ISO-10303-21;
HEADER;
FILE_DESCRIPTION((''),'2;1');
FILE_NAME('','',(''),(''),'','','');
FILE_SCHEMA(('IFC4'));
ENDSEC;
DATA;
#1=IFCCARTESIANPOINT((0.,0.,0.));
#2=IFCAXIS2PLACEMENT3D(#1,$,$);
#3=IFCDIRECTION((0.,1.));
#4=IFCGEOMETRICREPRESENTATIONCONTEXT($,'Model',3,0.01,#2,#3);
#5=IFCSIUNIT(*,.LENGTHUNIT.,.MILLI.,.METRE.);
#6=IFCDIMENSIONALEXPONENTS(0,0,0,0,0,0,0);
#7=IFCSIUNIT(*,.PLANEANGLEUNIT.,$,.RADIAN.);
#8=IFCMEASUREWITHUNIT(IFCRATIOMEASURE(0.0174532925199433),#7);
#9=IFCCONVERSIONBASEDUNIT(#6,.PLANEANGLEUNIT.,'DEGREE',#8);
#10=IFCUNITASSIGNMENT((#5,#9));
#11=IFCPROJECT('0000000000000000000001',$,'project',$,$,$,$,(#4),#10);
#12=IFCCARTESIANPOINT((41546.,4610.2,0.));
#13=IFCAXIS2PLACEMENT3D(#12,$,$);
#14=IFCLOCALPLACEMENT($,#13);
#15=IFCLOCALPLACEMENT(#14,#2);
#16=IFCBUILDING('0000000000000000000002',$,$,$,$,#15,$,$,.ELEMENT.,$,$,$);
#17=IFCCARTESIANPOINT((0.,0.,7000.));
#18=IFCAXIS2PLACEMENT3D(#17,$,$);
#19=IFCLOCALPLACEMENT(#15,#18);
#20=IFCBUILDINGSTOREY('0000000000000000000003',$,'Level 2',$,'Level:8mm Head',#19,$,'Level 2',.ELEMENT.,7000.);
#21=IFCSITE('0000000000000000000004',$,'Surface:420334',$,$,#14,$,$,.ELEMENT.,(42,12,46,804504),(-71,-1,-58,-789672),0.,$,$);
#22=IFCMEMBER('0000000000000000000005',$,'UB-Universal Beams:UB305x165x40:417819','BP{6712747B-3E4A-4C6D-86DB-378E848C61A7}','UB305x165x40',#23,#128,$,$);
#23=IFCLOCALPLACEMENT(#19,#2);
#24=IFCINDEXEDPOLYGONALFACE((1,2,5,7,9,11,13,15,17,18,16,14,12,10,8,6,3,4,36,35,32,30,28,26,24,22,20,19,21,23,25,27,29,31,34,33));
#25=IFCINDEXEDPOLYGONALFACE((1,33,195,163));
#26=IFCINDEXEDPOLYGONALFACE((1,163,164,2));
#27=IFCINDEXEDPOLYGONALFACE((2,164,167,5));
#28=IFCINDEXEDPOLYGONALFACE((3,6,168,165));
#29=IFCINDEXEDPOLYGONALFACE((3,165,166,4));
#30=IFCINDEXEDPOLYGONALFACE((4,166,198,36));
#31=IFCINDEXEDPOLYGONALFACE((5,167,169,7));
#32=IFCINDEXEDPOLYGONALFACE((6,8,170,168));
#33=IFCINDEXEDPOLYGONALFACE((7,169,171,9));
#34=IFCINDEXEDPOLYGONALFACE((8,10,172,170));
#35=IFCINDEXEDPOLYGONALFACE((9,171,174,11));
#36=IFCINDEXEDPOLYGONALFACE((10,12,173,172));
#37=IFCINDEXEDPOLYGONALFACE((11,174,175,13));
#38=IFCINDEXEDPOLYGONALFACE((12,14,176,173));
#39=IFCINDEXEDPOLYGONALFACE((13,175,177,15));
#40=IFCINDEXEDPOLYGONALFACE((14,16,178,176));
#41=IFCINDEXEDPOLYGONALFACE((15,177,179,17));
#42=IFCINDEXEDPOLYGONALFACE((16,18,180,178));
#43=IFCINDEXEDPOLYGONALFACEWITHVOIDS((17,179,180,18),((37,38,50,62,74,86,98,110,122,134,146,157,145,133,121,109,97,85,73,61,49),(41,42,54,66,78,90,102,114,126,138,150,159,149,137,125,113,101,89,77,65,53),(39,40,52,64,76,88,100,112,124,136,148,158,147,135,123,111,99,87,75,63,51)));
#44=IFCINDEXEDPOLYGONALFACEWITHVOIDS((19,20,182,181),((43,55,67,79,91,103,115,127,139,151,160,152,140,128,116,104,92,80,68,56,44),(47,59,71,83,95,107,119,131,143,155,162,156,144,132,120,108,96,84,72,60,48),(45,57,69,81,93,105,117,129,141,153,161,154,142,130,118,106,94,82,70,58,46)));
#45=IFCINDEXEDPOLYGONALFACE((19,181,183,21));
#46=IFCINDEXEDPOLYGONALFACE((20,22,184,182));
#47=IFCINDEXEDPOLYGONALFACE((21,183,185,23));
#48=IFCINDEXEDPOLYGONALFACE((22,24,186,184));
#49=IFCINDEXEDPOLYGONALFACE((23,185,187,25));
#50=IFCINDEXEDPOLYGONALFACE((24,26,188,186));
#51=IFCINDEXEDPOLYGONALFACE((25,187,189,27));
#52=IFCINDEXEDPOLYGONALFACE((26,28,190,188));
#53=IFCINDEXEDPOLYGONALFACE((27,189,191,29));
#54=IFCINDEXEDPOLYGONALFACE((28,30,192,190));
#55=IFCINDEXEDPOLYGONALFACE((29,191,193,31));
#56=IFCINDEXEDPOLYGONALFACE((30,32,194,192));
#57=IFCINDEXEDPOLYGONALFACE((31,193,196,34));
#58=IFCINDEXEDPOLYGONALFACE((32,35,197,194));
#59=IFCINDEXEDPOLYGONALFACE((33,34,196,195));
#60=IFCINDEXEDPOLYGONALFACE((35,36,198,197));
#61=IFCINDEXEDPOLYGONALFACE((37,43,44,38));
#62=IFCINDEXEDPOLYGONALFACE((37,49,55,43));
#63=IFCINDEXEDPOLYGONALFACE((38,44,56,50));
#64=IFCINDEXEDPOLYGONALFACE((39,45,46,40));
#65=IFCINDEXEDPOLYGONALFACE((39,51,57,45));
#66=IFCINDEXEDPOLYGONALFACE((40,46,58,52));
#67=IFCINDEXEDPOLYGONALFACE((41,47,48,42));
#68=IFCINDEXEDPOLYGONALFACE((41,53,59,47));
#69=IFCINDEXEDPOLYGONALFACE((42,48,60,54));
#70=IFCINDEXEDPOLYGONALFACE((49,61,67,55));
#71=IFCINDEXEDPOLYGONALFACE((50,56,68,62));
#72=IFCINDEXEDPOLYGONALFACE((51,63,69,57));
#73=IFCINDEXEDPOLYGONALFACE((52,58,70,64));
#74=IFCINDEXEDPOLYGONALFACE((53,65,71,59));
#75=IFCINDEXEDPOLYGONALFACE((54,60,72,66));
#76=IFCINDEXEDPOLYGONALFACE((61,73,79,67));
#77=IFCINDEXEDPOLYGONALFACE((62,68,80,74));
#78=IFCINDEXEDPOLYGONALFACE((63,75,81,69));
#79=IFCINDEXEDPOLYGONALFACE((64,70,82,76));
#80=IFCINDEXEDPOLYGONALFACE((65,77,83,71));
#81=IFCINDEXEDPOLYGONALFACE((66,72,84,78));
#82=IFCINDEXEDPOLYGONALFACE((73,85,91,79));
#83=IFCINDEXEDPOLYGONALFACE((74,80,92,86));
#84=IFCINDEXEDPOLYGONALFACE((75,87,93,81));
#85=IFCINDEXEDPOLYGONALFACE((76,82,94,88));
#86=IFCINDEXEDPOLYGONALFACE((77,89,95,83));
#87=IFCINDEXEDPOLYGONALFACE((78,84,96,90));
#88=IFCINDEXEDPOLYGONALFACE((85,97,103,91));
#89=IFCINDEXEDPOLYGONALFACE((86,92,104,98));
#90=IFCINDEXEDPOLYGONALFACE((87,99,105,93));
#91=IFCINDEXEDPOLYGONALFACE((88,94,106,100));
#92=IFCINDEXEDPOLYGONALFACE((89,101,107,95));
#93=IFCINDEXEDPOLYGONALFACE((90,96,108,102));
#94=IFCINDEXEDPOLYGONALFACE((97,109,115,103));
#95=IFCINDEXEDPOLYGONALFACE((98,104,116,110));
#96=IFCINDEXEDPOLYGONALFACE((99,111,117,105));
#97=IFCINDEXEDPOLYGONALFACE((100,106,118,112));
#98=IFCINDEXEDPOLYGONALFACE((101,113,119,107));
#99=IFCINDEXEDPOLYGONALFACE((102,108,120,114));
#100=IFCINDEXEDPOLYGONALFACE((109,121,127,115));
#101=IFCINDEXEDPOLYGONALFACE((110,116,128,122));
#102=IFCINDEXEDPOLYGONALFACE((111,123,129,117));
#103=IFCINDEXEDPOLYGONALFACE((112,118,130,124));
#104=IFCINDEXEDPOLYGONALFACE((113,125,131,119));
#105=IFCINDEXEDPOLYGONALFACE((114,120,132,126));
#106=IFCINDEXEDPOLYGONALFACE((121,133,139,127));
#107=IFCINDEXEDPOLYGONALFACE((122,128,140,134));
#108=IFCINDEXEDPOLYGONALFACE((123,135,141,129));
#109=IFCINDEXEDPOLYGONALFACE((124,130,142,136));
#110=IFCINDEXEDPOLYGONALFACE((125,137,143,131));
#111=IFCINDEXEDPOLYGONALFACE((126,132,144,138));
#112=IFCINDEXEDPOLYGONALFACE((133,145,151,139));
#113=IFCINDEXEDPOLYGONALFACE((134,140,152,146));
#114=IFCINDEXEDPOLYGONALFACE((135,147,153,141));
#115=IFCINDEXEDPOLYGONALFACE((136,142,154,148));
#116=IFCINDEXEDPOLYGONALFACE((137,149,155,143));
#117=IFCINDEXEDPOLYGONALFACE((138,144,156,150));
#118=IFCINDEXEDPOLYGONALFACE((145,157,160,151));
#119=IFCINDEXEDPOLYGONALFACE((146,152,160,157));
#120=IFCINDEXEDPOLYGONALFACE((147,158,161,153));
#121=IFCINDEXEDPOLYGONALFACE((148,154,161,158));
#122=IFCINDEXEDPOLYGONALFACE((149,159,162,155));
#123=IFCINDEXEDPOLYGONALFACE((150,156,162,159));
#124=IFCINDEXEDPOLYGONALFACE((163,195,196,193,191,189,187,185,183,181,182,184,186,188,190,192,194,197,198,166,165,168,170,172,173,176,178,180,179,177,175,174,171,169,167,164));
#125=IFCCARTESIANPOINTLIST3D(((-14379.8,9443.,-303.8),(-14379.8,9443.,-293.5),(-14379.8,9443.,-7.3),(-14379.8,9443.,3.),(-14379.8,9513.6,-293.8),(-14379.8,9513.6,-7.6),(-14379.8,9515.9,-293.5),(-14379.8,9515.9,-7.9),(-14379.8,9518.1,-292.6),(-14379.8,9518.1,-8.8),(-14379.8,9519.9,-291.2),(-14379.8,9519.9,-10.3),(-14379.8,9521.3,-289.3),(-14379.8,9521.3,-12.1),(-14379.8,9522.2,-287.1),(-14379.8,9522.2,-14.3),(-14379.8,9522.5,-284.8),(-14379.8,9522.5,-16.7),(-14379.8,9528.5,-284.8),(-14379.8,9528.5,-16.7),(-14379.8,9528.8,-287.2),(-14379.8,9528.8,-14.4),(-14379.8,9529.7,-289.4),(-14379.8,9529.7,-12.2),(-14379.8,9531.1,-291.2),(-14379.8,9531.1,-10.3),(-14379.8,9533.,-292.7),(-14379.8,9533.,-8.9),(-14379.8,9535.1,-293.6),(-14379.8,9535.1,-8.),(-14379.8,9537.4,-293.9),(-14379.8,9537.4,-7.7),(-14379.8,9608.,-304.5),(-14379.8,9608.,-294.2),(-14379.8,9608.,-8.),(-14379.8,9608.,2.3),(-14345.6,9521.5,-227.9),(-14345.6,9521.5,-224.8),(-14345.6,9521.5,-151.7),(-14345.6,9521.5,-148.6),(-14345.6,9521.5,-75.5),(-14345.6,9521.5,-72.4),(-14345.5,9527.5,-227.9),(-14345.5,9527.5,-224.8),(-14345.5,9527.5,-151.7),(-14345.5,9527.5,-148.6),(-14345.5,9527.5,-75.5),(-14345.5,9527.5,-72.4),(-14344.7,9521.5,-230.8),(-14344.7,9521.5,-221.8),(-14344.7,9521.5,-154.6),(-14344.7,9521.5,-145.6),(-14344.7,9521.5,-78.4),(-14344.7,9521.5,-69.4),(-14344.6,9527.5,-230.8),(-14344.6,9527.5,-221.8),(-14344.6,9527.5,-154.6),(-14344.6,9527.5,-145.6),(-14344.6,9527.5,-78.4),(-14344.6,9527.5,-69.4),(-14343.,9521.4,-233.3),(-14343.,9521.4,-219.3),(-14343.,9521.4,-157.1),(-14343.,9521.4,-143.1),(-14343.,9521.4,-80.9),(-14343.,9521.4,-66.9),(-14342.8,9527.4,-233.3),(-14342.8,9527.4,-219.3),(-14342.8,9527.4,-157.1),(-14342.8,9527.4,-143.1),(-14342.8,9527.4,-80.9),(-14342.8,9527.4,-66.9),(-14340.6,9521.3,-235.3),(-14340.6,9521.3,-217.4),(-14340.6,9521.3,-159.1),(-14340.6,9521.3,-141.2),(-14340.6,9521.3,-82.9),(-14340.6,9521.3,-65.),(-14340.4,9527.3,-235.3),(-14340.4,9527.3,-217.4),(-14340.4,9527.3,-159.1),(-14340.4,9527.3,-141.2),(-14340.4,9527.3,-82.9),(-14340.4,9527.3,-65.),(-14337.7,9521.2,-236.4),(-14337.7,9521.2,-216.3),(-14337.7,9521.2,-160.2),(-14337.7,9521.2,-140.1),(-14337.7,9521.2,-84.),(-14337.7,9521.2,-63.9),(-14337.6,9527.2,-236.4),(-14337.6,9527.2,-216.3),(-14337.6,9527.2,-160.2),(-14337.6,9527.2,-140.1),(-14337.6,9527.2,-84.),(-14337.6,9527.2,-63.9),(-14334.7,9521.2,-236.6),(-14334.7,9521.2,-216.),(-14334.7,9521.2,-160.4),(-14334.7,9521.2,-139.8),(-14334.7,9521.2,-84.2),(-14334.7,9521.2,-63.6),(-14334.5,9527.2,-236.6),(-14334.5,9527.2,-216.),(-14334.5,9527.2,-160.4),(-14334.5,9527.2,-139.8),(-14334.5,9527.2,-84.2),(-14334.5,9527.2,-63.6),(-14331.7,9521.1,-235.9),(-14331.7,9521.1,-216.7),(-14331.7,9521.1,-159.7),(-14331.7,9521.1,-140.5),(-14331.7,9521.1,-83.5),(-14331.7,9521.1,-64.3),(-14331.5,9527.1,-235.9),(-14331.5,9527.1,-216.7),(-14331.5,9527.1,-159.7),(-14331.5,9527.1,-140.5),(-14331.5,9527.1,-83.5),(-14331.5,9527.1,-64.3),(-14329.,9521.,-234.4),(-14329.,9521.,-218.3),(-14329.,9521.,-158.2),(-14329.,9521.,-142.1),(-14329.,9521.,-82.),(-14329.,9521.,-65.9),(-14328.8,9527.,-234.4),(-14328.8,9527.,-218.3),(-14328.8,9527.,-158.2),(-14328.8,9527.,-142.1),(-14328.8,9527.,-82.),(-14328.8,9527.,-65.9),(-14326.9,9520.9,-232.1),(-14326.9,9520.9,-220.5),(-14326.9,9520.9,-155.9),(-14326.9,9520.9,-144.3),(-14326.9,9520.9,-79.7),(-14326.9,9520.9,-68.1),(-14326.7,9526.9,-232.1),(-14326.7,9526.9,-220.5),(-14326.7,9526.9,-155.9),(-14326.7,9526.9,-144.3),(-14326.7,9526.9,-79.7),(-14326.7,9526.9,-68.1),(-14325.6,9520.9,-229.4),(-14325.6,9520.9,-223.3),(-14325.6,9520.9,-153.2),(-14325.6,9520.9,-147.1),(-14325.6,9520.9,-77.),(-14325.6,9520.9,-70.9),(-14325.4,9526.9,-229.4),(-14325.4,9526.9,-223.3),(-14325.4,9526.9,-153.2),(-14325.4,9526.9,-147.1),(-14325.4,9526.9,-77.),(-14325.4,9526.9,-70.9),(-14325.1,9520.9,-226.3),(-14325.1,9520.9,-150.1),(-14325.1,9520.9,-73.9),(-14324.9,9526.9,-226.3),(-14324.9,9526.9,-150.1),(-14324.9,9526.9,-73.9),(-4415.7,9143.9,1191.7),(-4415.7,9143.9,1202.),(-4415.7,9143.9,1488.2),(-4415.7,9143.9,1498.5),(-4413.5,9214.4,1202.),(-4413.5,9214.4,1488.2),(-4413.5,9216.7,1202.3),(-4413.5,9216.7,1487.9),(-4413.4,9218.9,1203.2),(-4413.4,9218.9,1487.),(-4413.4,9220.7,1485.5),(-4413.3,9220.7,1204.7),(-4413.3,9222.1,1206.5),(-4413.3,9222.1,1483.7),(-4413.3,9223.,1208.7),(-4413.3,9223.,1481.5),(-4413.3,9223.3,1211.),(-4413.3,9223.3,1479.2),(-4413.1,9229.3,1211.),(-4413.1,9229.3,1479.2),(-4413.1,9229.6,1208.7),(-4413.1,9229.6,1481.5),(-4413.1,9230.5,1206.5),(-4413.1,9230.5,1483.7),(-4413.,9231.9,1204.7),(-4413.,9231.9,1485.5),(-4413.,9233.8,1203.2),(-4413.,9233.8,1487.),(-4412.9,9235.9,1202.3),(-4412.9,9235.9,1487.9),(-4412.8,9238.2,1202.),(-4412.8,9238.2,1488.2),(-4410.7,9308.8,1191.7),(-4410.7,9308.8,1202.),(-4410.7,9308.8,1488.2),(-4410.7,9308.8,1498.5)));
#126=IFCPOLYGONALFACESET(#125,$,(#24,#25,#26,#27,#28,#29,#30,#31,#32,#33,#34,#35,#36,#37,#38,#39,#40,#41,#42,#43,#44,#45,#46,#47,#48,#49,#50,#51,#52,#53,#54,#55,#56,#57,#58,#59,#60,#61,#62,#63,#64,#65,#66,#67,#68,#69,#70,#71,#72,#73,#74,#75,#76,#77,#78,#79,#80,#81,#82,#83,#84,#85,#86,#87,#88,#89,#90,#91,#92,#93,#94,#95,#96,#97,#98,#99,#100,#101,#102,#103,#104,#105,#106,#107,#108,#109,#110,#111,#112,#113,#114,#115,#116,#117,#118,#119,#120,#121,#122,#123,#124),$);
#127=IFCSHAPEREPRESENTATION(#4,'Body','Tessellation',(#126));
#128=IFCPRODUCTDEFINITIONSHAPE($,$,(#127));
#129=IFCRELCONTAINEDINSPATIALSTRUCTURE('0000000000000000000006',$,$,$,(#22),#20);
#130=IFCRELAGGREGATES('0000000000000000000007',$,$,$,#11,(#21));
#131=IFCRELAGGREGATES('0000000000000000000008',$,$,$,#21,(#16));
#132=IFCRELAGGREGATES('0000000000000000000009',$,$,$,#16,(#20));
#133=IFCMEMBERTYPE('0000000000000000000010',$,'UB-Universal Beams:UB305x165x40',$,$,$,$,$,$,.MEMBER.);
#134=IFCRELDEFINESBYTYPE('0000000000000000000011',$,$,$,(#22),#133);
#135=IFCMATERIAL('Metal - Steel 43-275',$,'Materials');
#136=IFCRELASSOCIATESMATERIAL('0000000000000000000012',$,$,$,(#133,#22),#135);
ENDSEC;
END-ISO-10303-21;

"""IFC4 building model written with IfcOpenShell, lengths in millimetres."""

from ifc_helpers import new_model, entity, si_unit, converted_unit, direction, frame, frame_2d, origin, origin_2d, origin_2d_with_axis, place, context, project, spatial, circle, i_section, extrude, clip, halfspace, material, type_object, element, save


model = new_model("IFC4")

# Units and contexts
model_context = context("Model", 3, precision=0.01, world=origin(), true_north=direction((0.0, 1.0)))
ifc_project = project(units=[si_unit("LENGTHUNIT", "METRE", prefix="MILLI"), converted_unit("PLANEANGLEUNIT", "DEGREE", entity("IfcRatioMeasure", 0.0174532925199433), si_unit("PLANEANGLEUNIT", "RADIAN"), dimensions=[0, 0, 0, 0, 0, 0, 0])], contexts=[model_context])

# Site, building, storey
site_placement = place(None, frame((41546.0, 4610.2, 0.0)))
site = spatial("IfcSite", under=ifc_project, at=site_placement, Name="Surface:420334", CompositionType="ELEMENT", RefLatitude=(42, 12, 46, 804504), RefLongitude=(-71, -1, -58, -789672), RefElevation=0.0)
building_placement = place(site_placement, origin())
building = spatial("IfcBuilding", under=site, at=building_placement, CompositionType="ELEMENT")
storey_placement = place(building_placement, frame((0.0, 0.0, 7000.0)))
storey = spatial("IfcBuildingStorey", under=building, at=storey_placement, Name="Level 2", ObjectType="Level:8mm Head", LongName="Level 2", CompositionType="ELEMENT", Elevation=7000.0)

# Shared definitions
ifc_material = material(Name="Metal - Steel 43-275", Category="Materials")

# Member, openings
member_type_1 = type_object("IfcMemberType", Name="UB-Universal Beams:UB305x165x40", PredefinedType="MEMBER", material=ifc_material)
member_1_placement = place(storey_placement, frame((-14851.0, 9539.7, -221.5), z_axis=(-0.988488, 0.029672, -0.148359), x_axis=(-0.030004, -0.99955, 0.0)))
member_1 = element("IfcMember", 1, at=member_1_placement, inside=storey, type_object=member_type_1, material=ifc_material, Name="UB-Universal Beams:UB305x165x40:417819", Description="BP{6712747B-3E4A-4C6D-86DB-378E848C61A7}", ObjectType="UB305x165x40", context=model_context, shape_type="Clipping", body=[
    clip(clip(extrude(i_section(OverallWidth=165.0, OverallDepth=303.4, WebThickness=6.0, FlangeThickness=10.2, FilletRadius=8.9, at=origin_2d()), origin(), (0.0, 0.0, -1.0), 11073.7), halfspace(frame((9089.8, -8252.9, -9321.5), z_axis=(0.0, 0.14834, 0.988936), x_axis=(1.0, 0.0, 0.0)), True)), halfspace(frame((9521.2, -6815.9, 256.8), z_axis=(-0.030004, -0.148292, -0.988488), x_axis=(-0.99955, 0.004451, 0.029672)), True)),
])
opening_1_placement = place(member_1_placement, frame((3.5, -6.0, -520.8), z_axis=(-1.0, 0.0, 0.0), x_axis=(0.0, -0.148359, -0.988934)))
element("IfcOpeningElement", 2, at=opening_1_placement, cuts=member_1, ObjectType="Opening", context=model_context, shape_type="SweptSolid", body=[
    extrude(circle(Radius=10.3, at=origin_2d_with_axis()), origin(), (0.0, 0.0, 1.0), 7.0),
])
opening_2_placement = place(member_1_placement, frame((3.5, -6.0, -520.8), z_axis=(-1.0, 0.0, 0.0), x_axis=(0.0, -0.148359, -0.988934)))
element("IfcOpeningElement", 3, at=opening_2_placement, cuts=member_1, ObjectType="Opening", context=model_context, shape_type="SweptSolid", body=[
    extrude(circle(Radius=10.3, at=frame_2d((0.0, 76.2), x_axis=(1.0, 0.0))), origin(), (0.0, 0.0, 1.0), 7.0),
])
opening_3_placement = place(member_1_placement, frame((3.5, -6.0, -520.8), z_axis=(-1.0, 0.0, 0.0), x_axis=(0.0, -0.148359, -0.988934)))
element("IfcOpeningElement", 4, at=opening_3_placement, cuts=member_1, ObjectType="Opening", context=model_context, shape_type="SweptSolid", body=[
    extrude(circle(Radius=10.3, at=frame_2d((0.0, -76.2), x_axis=(1.0, 0.0))), origin(), (0.0, 0.0, 1.0), 7.0),
])

save(model, "model.ifc")
